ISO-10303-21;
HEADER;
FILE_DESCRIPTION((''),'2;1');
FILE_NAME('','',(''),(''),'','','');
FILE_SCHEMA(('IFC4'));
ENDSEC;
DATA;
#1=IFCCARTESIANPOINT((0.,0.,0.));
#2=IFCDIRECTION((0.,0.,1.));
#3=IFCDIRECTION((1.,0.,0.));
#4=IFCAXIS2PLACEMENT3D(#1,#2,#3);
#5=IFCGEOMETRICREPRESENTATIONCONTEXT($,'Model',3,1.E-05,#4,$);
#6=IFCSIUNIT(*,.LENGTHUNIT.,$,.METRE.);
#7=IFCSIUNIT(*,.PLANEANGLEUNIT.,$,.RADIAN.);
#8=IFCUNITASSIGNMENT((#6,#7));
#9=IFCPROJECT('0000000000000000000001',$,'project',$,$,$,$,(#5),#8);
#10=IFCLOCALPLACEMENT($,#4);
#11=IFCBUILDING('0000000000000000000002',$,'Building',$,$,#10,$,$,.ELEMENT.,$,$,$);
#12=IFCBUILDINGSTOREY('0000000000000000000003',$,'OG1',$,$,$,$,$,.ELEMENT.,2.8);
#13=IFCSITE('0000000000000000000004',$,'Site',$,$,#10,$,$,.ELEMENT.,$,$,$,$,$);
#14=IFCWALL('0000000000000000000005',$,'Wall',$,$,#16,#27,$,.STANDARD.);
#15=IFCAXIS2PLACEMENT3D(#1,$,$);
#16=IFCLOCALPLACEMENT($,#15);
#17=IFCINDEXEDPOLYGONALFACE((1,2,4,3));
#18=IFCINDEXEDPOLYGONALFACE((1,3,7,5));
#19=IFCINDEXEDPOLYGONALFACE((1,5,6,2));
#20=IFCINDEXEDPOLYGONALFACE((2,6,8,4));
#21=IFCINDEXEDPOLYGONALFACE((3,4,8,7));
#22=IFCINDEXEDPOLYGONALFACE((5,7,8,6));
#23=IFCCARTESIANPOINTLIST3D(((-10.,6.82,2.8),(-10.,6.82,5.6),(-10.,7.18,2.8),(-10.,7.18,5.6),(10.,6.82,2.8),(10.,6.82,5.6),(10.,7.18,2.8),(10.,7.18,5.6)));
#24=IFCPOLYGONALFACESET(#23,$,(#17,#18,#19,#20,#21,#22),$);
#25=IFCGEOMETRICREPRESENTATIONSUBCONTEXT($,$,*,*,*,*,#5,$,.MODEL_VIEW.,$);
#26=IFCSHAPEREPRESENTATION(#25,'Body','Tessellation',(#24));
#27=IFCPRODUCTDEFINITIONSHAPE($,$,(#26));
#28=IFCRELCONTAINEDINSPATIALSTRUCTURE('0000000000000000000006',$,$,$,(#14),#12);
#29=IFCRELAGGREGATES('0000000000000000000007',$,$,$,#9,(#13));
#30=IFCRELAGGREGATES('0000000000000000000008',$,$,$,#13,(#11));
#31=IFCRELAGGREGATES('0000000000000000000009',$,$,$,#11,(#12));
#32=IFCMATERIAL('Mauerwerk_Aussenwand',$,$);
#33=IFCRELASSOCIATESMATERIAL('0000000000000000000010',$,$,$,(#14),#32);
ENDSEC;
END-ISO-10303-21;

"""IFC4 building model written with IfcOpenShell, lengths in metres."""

from ifc_helpers import new_model, si_unit, frame, frame_2d, origin, origin_with_axes, place, context, subcontext, project, spatial, rectangle, extrude, material, element, save


model = new_model("IFC4")

# Units and contexts
model_context = context("Model", 3, precision=1e-05, world=origin_with_axes())
sub_context = subcontext(model_context, None, None, "MODEL_VIEW")
ifc_project = project(units=[si_unit("LENGTHUNIT", "METRE"), si_unit("PLANEANGLEUNIT", "RADIAN")], contexts=[model_context])

# Site, building, storey
placement_1 = place(None, origin_with_axes())
site = spatial("IfcSite", under=ifc_project, at=placement_1, Name="Site", CompositionType="ELEMENT")
building = spatial("IfcBuilding", under=site, at=placement_1, Name="Building", CompositionType="ELEMENT")
storey = spatial("IfcBuildingStorey", under=building, Name="OG1", CompositionType="ELEMENT", Elevation=2.8)

# Wall
ifc_material = material(Name="Mauerwerk_Aussenwand")
placement_2 = place(None, origin_with_axes())
placement_3 = place(placement_2, frame((0.0, 0.0, 2.8)))
wall_placement = place(placement_3, frame((10.0, 7.0, 0.0), x_axis=(-1.0, 0.0, 0.0)))
element("IfcWall", 1, at=wall_placement, inside=storey, material=ifc_material, Name="Wall", PredefinedType="STANDARD", context=sub_context, shape_type="SweptSolid", body=[
    extrude(rectangle(XDim=20.0, YDim=0.36, at=frame_2d((10.0, 0.0))), origin(), (0.0, 0.0, 1.0), 2.8),
])

save(model, "model.ifc")
